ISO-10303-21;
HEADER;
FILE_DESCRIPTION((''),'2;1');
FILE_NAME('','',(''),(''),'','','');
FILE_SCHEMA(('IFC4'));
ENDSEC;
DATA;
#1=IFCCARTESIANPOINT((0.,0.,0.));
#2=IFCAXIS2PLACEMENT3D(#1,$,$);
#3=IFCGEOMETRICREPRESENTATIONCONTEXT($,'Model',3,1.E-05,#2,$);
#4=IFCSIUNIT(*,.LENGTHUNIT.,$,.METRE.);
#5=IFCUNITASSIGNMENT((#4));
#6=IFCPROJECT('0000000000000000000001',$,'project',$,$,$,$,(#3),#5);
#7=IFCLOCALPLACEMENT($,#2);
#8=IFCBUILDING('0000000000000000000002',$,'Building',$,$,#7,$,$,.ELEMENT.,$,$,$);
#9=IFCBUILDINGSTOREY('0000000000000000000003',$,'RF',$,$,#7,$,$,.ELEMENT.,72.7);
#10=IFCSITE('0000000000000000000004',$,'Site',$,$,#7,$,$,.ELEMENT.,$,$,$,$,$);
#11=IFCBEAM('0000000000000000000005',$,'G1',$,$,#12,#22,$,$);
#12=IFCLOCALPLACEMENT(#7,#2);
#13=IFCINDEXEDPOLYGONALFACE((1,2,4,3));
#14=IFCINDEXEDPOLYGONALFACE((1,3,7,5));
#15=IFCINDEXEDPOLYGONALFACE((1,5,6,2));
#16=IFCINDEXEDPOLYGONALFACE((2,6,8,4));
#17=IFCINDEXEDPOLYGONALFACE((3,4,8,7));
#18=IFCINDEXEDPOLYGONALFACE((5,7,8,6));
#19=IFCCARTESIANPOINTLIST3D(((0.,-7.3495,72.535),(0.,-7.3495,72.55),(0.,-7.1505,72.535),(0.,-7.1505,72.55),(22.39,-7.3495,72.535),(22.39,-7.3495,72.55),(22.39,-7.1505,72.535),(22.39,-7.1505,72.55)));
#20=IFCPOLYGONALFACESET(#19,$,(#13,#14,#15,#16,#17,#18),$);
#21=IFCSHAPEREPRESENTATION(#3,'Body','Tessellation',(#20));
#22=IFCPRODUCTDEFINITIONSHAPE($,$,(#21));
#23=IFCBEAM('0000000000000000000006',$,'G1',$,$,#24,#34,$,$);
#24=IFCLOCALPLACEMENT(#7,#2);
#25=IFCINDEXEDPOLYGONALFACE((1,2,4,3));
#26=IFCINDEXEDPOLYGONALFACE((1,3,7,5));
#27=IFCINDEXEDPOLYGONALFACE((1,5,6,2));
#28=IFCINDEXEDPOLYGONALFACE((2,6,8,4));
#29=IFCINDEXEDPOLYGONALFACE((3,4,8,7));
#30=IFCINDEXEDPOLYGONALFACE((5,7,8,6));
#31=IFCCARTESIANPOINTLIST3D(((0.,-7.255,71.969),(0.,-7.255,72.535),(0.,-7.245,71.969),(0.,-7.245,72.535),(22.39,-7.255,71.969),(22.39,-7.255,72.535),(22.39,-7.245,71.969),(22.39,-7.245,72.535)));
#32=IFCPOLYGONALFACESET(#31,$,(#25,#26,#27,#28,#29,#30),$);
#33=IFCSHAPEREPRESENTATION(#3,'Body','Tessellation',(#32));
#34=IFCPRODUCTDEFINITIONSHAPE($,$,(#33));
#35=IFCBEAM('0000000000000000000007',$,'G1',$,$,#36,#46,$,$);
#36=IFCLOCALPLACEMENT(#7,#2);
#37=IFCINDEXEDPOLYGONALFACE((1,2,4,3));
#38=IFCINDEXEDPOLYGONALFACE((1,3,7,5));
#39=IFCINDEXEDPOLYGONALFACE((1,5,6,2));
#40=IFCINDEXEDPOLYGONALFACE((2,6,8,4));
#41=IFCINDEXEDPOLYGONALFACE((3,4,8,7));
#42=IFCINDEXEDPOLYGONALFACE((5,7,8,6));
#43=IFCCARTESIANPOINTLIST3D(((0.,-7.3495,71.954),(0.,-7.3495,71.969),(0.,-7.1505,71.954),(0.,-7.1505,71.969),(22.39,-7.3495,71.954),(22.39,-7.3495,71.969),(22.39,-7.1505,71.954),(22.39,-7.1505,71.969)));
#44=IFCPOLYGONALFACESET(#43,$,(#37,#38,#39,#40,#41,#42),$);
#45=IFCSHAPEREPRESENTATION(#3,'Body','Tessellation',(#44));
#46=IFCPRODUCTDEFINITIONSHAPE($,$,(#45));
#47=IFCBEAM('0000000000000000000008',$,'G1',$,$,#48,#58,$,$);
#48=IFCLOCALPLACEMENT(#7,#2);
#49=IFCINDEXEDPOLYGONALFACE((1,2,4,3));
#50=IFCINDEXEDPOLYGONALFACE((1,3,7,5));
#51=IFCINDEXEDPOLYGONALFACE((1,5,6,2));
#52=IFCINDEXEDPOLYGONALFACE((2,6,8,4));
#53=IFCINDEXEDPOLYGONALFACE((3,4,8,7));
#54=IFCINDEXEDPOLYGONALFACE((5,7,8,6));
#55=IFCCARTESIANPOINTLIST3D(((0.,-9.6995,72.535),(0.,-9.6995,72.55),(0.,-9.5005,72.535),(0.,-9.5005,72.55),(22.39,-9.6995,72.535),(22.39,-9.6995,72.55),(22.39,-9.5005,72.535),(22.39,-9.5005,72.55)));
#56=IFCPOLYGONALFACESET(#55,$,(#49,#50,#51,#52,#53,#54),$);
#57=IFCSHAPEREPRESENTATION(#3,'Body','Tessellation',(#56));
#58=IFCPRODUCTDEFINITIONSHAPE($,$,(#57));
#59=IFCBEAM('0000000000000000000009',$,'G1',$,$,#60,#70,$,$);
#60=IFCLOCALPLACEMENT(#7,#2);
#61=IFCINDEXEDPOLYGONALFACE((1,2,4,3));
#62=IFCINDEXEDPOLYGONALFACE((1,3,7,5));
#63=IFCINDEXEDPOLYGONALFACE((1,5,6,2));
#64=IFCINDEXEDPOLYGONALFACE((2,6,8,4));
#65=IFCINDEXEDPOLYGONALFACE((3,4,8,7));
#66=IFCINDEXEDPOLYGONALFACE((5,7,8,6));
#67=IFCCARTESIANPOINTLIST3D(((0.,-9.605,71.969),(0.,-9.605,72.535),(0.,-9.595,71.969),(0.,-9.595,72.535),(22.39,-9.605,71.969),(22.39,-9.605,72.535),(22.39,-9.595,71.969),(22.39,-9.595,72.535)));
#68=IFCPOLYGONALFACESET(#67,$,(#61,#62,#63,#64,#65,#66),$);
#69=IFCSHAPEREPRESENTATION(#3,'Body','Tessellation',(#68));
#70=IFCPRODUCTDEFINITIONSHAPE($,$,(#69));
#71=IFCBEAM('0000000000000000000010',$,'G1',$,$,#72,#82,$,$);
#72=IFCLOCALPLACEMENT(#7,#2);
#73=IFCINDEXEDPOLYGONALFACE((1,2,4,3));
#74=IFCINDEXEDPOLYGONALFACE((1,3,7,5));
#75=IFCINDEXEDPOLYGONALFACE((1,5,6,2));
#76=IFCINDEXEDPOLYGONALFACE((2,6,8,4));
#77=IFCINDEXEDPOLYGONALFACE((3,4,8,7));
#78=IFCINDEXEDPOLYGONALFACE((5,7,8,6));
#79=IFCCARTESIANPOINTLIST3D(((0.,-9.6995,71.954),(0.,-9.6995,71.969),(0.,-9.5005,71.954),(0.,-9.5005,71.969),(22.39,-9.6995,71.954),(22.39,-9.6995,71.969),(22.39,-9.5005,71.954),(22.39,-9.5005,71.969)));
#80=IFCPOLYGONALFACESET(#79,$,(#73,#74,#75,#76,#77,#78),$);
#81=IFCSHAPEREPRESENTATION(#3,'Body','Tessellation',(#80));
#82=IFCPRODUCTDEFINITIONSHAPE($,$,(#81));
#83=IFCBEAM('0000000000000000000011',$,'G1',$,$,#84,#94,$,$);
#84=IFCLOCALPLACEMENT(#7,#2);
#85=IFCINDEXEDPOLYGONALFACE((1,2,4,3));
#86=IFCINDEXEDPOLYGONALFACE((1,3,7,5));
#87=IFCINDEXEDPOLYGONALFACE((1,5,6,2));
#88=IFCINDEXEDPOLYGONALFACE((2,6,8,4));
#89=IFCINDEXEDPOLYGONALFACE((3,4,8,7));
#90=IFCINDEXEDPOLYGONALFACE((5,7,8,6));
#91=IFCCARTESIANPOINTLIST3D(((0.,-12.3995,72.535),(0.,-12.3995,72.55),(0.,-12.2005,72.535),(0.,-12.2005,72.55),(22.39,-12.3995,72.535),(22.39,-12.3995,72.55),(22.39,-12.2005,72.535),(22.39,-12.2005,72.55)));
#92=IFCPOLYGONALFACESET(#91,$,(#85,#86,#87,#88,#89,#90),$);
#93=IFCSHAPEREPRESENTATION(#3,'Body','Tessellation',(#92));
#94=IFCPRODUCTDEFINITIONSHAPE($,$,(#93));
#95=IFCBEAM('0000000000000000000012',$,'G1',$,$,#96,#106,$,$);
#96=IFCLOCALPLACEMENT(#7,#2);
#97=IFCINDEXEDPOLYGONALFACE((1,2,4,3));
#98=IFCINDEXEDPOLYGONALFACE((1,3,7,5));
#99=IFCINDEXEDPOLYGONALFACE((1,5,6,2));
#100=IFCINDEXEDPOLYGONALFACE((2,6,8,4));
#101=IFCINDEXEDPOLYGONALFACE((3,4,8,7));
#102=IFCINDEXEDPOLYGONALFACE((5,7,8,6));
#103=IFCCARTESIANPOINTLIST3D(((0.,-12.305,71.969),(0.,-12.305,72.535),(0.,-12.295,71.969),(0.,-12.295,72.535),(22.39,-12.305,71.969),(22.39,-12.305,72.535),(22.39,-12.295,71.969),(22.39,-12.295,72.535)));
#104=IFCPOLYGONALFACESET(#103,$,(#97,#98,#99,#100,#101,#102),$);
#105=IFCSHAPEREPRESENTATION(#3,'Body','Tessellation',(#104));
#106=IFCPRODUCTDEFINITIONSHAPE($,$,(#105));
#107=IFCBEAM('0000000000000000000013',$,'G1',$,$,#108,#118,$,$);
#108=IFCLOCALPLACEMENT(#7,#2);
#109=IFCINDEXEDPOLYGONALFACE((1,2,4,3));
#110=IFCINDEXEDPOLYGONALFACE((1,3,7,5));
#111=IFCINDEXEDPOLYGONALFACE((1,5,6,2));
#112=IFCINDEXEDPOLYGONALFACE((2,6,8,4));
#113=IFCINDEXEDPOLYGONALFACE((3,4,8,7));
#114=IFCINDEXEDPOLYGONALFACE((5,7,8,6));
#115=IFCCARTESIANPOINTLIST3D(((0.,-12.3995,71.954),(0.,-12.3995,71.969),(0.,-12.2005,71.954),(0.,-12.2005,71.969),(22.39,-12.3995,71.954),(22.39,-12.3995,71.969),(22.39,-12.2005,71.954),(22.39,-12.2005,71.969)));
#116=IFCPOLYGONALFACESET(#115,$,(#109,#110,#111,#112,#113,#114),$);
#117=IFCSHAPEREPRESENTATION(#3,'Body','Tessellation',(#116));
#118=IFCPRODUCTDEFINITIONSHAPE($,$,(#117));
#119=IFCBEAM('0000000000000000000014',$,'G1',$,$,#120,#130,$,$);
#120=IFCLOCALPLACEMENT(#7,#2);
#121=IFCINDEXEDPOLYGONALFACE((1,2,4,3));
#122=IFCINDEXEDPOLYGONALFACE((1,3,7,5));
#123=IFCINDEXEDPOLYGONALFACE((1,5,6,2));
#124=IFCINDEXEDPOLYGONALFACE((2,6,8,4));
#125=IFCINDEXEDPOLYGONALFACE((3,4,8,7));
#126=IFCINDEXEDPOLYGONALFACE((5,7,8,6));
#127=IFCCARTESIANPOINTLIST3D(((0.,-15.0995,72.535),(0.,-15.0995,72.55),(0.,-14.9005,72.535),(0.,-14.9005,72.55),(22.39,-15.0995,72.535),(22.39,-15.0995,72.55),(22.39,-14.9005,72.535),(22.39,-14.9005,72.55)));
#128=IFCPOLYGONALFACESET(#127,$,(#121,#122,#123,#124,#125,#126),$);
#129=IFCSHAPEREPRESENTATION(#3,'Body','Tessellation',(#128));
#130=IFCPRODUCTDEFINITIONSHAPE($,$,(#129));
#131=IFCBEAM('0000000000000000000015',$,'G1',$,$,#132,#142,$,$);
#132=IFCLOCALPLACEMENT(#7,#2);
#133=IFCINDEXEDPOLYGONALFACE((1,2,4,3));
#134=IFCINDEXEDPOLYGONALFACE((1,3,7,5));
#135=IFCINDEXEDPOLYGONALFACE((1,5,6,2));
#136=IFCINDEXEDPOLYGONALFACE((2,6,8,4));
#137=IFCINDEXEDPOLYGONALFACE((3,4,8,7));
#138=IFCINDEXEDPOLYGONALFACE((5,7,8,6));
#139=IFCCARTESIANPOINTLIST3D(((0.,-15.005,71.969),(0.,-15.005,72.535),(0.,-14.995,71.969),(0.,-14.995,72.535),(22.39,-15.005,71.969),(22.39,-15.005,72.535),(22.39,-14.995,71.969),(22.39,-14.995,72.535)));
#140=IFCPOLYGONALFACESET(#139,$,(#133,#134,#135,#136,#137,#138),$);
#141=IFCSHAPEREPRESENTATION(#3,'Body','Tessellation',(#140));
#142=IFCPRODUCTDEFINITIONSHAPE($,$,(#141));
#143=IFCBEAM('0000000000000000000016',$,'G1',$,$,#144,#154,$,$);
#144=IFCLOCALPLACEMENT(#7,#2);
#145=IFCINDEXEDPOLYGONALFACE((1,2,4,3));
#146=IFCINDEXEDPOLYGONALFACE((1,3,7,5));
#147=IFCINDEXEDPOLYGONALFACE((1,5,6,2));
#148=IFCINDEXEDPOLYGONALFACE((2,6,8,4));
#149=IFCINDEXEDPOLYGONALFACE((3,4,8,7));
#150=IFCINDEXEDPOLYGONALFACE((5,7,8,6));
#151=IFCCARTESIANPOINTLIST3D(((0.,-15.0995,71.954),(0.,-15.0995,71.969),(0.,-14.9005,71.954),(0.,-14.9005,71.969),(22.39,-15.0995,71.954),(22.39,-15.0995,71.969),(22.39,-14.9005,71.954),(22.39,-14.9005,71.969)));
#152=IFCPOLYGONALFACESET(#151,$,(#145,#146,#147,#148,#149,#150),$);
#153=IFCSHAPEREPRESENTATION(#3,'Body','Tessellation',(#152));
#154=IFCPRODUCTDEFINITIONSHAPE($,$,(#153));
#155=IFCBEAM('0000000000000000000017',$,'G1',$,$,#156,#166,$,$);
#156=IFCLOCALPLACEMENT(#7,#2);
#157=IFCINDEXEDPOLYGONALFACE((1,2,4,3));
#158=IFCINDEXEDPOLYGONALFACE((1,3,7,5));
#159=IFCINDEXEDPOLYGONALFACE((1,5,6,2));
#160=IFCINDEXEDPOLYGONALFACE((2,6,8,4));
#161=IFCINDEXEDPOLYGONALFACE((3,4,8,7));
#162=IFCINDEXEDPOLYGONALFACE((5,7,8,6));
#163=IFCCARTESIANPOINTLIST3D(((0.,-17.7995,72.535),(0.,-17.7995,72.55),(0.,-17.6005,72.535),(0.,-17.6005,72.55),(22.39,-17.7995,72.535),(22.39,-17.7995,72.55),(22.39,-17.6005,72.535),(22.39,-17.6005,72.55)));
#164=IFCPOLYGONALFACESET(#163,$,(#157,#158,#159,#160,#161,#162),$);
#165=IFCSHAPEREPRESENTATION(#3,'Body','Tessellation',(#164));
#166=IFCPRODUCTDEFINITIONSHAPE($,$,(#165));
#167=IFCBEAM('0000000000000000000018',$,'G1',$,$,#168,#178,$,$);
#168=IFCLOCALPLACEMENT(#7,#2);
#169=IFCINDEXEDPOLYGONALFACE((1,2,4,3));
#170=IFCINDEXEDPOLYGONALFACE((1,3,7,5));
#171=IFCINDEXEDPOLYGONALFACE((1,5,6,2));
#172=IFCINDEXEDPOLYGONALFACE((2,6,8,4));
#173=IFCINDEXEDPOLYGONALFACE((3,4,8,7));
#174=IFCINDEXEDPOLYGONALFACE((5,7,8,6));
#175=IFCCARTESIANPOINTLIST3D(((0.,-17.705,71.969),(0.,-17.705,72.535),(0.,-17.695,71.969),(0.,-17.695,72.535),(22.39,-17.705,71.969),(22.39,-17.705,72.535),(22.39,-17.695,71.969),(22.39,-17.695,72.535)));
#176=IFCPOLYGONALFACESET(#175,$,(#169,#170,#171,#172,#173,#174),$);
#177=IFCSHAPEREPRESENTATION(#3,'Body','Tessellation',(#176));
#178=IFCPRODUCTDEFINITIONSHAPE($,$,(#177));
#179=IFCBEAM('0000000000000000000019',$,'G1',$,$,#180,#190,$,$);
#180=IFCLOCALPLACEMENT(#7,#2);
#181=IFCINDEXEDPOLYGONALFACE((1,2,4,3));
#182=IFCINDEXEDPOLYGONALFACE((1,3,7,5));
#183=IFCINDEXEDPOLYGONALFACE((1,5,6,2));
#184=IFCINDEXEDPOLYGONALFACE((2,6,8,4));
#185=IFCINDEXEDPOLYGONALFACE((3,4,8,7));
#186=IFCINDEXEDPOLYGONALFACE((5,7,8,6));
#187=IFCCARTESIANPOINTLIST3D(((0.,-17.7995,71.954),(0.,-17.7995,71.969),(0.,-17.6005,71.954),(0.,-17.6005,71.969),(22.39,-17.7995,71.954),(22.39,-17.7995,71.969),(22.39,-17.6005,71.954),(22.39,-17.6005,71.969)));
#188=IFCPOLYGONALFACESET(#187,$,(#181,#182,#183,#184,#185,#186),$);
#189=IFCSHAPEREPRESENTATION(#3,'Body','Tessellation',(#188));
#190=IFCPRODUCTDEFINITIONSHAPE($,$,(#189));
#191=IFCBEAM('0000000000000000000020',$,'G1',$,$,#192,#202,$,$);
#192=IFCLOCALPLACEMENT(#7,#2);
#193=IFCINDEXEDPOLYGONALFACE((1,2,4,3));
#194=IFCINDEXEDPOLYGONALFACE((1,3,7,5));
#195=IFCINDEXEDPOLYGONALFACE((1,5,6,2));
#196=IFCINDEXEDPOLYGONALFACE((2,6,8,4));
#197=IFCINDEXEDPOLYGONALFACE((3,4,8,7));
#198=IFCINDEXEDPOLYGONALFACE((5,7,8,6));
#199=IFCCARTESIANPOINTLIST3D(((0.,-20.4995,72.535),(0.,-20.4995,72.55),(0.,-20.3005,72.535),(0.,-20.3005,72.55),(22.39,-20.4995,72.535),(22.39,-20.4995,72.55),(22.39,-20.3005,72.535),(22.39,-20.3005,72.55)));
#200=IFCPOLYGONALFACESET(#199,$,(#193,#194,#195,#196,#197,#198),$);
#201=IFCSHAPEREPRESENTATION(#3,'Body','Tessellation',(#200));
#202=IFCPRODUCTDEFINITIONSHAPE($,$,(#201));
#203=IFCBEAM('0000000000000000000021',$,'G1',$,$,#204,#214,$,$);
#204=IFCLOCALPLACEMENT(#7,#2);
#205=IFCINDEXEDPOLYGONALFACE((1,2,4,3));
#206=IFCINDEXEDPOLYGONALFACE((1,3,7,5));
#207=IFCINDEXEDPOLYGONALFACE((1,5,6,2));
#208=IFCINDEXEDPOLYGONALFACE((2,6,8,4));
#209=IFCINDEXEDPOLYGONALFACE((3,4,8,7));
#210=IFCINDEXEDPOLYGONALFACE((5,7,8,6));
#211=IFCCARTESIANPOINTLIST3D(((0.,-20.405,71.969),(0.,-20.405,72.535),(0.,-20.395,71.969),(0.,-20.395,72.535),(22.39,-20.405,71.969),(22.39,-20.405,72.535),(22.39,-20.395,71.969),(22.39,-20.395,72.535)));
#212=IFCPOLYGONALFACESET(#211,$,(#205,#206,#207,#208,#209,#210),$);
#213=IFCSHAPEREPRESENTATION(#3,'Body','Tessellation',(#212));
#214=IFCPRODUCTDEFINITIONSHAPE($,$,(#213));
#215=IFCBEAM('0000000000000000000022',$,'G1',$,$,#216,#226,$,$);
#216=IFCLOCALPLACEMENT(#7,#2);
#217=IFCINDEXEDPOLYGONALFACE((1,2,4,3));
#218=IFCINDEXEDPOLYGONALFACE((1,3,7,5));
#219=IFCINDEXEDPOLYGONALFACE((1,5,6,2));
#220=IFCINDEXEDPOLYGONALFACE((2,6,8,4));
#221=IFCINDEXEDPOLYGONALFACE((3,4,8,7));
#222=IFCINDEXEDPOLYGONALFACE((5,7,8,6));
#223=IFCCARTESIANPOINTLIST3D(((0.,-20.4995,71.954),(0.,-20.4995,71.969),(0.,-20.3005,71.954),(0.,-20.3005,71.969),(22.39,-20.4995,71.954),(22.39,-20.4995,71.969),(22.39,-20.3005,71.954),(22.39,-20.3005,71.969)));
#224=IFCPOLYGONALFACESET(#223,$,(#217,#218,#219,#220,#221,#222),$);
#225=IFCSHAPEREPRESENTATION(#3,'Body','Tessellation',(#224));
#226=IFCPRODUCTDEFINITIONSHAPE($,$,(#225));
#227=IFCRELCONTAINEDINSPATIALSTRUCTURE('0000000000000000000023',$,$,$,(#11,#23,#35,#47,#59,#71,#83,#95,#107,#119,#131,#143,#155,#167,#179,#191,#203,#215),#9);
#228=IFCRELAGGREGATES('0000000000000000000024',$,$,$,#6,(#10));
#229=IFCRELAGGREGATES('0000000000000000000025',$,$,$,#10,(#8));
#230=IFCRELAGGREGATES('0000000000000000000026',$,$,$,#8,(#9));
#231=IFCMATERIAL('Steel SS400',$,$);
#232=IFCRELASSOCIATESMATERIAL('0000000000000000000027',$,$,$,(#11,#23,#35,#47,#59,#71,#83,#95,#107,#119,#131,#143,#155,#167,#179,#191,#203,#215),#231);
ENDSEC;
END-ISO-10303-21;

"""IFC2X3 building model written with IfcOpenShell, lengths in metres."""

from ifc_helpers import new_model, si_unit, frame, origin, origin_2d, place, context, project, spatial, rectangle, extrude, material, element, save


model = new_model("IFC2X3")

# Units and contexts
model_context = context("Model", 3, precision=1e-05, world=origin())
ifc_project = project(units=[si_unit("LENGTHUNIT", "METRE")], contexts=[model_context])

# Site, building, storey
placement = place(None, origin())
site = spatial("IfcSite", under=ifc_project, at=placement, Name="Site", CompositionType="ELEMENT")
building = spatial("IfcBuilding", under=site, at=placement, Name="Building", CompositionType="ELEMENT")
storey = spatial("IfcBuildingStorey", under=building, at=placement, Name="RF", CompositionType="ELEMENT", Elevation=72.7)

# Beams
ifc_material_1 = material(Name="Steel SS400")
beam_1_placement = place(None, frame((11.195, -7.25, 72.535)))
element("IfcBeam", 1, at=beam_1_placement, inside=storey, material=ifc_material_1, Name="G1", context=model_context, shape_type="SweptSolid", body=[
    extrude(rectangle(XDim=22.39, YDim=0.199, at=origin_2d()), origin(), (0.0, 0.0, 1.0), 0.015),
])
beam_2_placement = place(None, frame((11.195, -7.25, 71.969)))
element("IfcBeam", 2, at=beam_2_placement, inside=storey, material=ifc_material_1, Name="G1", context=model_context, shape_type="SweptSolid", body=[
    extrude(rectangle(XDim=22.39, YDim=0.01, at=origin_2d()), origin(), (0.0, 0.0, 1.0), 0.566),
])
for number, where, name in (
    (3, (11.195, -7.25, 71.954), "G1"),
    (4, (11.195, -9.6, 72.535), "G1"),
):
    element("IfcBeam", number, at=place(None, frame(where)), inside=storey, material=ifc_material_1, Name=name, context=model_context, shape_type="SweptSolid", body=[
        extrude(rectangle(XDim=22.39, YDim=0.199, at=origin_2d()), origin(), (0.0, 0.0, 1.0), 0.015),
    ])
beam_3_placement = place(None, frame((11.195, -9.6, 71.969)))
element("IfcBeam", 5, at=beam_3_placement, inside=storey, material=ifc_material_1, Name="G1", context=model_context, shape_type="SweptSolid", body=[
    extrude(rectangle(XDim=22.39, YDim=0.01, at=origin_2d()), origin(), (0.0, 0.0, 1.0), 0.566),
])
for number, where, name in (
    (6, (11.195, -9.6, 71.954), "G1"),
    (7, (11.195, -12.3, 72.535), "G1"),
):
    element("IfcBeam", number, at=place(None, frame(where)), inside=storey, material=ifc_material_1, Name=name, context=model_context, shape_type="SweptSolid", body=[
        extrude(rectangle(XDim=22.39, YDim=0.199, at=origin_2d()), origin(), (0.0, 0.0, 1.0), 0.015),
    ])
beam_4_placement = place(None, frame((11.195, -12.3, 71.969)))
element("IfcBeam", 8, at=beam_4_placement, inside=storey, material=ifc_material_1, Name="G1", context=model_context, shape_type="SweptSolid", body=[
    extrude(rectangle(XDim=22.39, YDim=0.01, at=origin_2d()), origin(), (0.0, 0.0, 1.0), 0.566),
])
for number, where, name in (
    (9, (11.195, -12.3, 71.954), "G1"),
    (10, (11.195, -15.0, 72.535), "G1"),
):
    element("IfcBeam", number, at=place(None, frame(where)), inside=storey, material=ifc_material_1, Name=name, context=model_context, shape_type="SweptSolid", body=[
        extrude(rectangle(XDim=22.39, YDim=0.199, at=origin_2d()), origin(), (0.0, 0.0, 1.0), 0.015),
    ])
beam_5_placement = place(None, frame((11.195, -15.0, 71.969)))
element("IfcBeam", 11, at=beam_5_placement, inside=storey, material=ifc_material_1, Name="G1", context=model_context, shape_type="SweptSolid", body=[
    extrude(rectangle(XDim=22.39, YDim=0.01, at=origin_2d()), origin(), (0.0, 0.0, 1.0), 0.566),
])
for number, where, name in (
    (12, (11.195, -15.0, 71.954), "G1"),
    (13, (11.195, -17.7, 72.535), "G1"),
):
    element("IfcBeam", number, at=place(None, frame(where)), inside=storey, material=ifc_material_1, Name=name, context=model_context, shape_type="SweptSolid", body=[
        extrude(rectangle(XDim=22.39, YDim=0.199, at=origin_2d()), origin(), (0.0, 0.0, 1.0), 0.015),
    ])
beam_6_placement = place(None, frame((11.195, -17.7, 71.969)))
element("IfcBeam", 14, at=beam_6_placement, inside=storey, material=ifc_material_1, Name="G1", context=model_context, shape_type="SweptSolid", body=[
    extrude(rectangle(XDim=22.39, YDim=0.01, at=origin_2d()), origin(), (0.0, 0.0, 1.0), 0.566),
])
for number, where, name in (
    (15, (11.195, -17.7, 71.954), "G1"),
    (16, (11.195, -20.4, 72.535), "G1"),
):
    element("IfcBeam", number, at=place(None, frame(where)), inside=storey, material=ifc_material_1, Name=name, context=model_context, shape_type="SweptSolid", body=[
        extrude(rectangle(XDim=22.39, YDim=0.199, at=origin_2d()), origin(), (0.0, 0.0, 1.0), 0.015),
    ])
beam_7_placement = place(None, frame((11.195, -20.4, 71.969)))
element("IfcBeam", 17, at=beam_7_placement, inside=storey, material=ifc_material_1, Name="G1", context=model_context, shape_type="SweptSolid", body=[
    extrude(rectangle(XDim=22.39, YDim=0.01, at=origin_2d()), origin(), (0.0, 0.0, 1.0), 0.566),
])
beam_8_placement = place(None, frame((11.195, -20.4, 71.954)))
element("IfcBeam", 18, at=beam_8_placement, inside=storey, material=ifc_material_1, Name="G1", context=model_context, shape_type="SweptSolid", body=[
    extrude(rectangle(XDim=22.39, YDim=0.199, at=origin_2d()), origin(), (0.0, 0.0, 1.0), 0.015),
])

save(model, "model.ifc")
